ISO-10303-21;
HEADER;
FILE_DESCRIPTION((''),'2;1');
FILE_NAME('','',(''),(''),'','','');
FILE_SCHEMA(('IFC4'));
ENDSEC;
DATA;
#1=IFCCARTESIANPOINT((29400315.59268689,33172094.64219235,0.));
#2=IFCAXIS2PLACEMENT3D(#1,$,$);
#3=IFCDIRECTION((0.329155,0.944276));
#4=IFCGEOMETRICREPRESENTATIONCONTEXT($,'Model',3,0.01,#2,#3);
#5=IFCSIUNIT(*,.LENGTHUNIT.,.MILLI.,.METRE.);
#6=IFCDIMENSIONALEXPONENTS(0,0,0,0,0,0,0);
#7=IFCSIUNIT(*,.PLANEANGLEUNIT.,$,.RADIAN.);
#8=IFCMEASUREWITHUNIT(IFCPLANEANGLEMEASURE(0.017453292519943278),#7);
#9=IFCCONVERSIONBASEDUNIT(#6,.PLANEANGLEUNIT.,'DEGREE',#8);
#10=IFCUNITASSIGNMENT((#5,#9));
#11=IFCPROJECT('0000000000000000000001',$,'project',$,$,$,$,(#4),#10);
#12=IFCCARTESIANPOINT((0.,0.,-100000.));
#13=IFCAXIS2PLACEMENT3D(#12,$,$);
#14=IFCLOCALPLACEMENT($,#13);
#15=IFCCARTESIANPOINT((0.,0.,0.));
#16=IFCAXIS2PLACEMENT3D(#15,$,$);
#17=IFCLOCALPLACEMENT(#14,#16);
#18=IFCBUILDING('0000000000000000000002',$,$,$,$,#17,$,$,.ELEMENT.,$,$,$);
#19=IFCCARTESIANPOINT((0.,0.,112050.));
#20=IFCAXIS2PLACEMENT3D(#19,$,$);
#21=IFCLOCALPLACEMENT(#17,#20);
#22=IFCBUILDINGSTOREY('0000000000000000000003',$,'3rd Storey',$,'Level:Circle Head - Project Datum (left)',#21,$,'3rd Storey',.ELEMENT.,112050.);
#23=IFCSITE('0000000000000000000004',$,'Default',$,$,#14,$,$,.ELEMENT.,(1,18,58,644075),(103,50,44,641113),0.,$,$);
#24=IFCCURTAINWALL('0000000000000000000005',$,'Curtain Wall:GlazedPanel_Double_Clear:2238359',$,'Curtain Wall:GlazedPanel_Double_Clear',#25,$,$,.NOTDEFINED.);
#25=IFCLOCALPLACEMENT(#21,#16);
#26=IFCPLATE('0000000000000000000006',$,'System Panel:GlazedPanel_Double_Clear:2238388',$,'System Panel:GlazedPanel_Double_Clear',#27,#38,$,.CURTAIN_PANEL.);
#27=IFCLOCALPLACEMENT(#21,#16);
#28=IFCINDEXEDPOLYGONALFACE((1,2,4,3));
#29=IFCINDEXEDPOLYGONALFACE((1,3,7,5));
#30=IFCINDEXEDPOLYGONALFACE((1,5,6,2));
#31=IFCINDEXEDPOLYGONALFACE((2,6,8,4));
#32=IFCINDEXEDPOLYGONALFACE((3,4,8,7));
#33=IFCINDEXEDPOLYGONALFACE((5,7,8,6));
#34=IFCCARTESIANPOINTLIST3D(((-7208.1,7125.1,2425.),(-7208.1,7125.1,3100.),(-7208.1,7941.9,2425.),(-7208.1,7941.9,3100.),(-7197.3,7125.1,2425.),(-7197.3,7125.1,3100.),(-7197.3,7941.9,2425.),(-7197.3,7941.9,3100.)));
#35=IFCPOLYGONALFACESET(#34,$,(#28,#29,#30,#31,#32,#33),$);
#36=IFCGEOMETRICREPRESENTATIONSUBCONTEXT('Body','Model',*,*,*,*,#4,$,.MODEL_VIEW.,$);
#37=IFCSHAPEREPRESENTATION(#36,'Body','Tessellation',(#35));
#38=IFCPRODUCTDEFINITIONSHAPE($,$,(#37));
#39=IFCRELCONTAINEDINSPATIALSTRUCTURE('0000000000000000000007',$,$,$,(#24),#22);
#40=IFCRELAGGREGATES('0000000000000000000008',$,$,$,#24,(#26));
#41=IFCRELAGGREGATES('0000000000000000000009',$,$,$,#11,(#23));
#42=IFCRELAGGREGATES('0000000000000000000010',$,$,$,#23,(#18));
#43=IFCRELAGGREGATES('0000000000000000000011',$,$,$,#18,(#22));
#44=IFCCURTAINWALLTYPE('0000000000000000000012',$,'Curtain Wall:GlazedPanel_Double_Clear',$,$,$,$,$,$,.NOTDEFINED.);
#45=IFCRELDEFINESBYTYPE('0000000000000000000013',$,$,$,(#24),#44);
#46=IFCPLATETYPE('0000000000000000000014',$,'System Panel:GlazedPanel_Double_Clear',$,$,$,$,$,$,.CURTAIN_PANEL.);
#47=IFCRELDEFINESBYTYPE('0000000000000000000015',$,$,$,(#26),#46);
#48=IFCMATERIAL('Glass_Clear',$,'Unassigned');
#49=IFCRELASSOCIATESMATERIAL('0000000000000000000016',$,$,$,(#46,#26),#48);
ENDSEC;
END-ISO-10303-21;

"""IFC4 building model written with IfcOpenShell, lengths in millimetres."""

from ifc_helpers import new_model, entity, si_unit, converted_unit, direction, frame, origin, place, context, subcontext, project, spatial, indexed_curve, outline, extrude, source, transform, mapped, material, type_object, type_shapes, element, aggregate, save


model = new_model("IFC4")

# Units and contexts
model_context = context("Model", 3, precision=0.01, world=frame((29400315.59268689, 33172094.64219235, 0.0)), true_north=direction((0.329155, 0.944276)))
body_context = subcontext(model_context, "Body", "Model", "MODEL_VIEW")
ifc_project = project(units=[si_unit("LENGTHUNIT", "METRE", prefix="MILLI"), converted_unit("PLANEANGLEUNIT", "DEGREE", entity("IfcPlaneAngleMeasure", 0.017453292519943278), si_unit("PLANEANGLEUNIT", "RADIAN"), dimensions=[0, 0, 0, 0, 0, 0, 0])], contexts=[model_context])

# Site, building, storey
site_placement = place(None, frame((0.0, 0.0, -100000.0)))
site = spatial("IfcSite", under=ifc_project, at=site_placement, Name="Default", CompositionType="ELEMENT", RefLatitude=(1, 18, 58, 644075), RefLongitude=(103, 50, 44, 641113), RefElevation=0.0)
building_placement = place(site_placement, origin())
building = spatial("IfcBuilding", under=site, at=building_placement, CompositionType="ELEMENT")
storey_placement = place(building_placement, frame((0.0, 0.0, 112050.0)))
storey = spatial("IfcBuildingStorey", under=building, at=storey_placement, Name="3rd Storey", ObjectType="Level:Circle Head - Project Datum (left)", LongName="3rd Storey", CompositionType="ELEMENT", Elevation=112050.0)

# Curtain wall
curtain_wall_type = type_object("IfcCurtainWallType", Name="Curtain Wall:GlazedPanel_Double_Clear", PredefinedType="NOTDEFINED")
curtain_wall_1_placement = place(storey_placement, frame((0.0, 0.0, -112050.0)))
curtain_wall_1 = element("IfcCurtainWall", 1, at=curtain_wall_1_placement, inside=storey, type_object=curtain_wall_type, Name="Curtain Wall:GlazedPanel_Double_Clear:2238359", ObjectType="Curtain Wall:GlazedPanel_Double_Clear", PredefinedType="NOTDEFINED")

# Plate
ifc_material_1 = material(Name="Glass_Clear", Category="Unassigned")
plate_type_1 = type_object("IfcPlateType", Name="System Panel:GlazedPanel_Double_Clear", PredefinedType="CURTAIN_PANEL", material=ifc_material_1)
shared_shape_1 = source(origin(), body_context, "Body", "SweptSolid", [
    extrude(outline(indexed_curve([(-5.4, -408.4), (5.4, -408.4), (5.4, 408.4), (-5.4, 408.4), (-5.4, -408.4)], self_intersect=False)), frame((0.0, 111.0, 0.0), z_axis=(0.0, 0.0, 1.0), x_axis=(0.0, 1.0, 0.0)), (0.0, 0.0, 1.0), 675.0),
])
type_shapes(plate_type_1, [shared_shape_1])
plate_1_placement = place(curtain_wall_1_placement, frame((-7313.7, 7533.5, 114475.0), z_axis=(0.0, 0.0, 1.0), x_axis=(0.0, -1.0, 0.0)))
plate_1 = element("IfcPlate", 2, at=plate_1_placement, type_object=plate_type_1, material=ifc_material_1, Name="System Panel:GlazedPanel_Double_Clear:2238388", ObjectType="System Panel:GlazedPanel_Double_Clear", PredefinedType="CURTAIN_PANEL", context=body_context, shape_type="MappedRepresentation", body=[
    mapped(shared_shape_1, transform((0.0, 0.0, 0.0), scale=1.0)),
])
aggregate(curtain_wall_1, [plate_1])

save(model, "model.ifc")
